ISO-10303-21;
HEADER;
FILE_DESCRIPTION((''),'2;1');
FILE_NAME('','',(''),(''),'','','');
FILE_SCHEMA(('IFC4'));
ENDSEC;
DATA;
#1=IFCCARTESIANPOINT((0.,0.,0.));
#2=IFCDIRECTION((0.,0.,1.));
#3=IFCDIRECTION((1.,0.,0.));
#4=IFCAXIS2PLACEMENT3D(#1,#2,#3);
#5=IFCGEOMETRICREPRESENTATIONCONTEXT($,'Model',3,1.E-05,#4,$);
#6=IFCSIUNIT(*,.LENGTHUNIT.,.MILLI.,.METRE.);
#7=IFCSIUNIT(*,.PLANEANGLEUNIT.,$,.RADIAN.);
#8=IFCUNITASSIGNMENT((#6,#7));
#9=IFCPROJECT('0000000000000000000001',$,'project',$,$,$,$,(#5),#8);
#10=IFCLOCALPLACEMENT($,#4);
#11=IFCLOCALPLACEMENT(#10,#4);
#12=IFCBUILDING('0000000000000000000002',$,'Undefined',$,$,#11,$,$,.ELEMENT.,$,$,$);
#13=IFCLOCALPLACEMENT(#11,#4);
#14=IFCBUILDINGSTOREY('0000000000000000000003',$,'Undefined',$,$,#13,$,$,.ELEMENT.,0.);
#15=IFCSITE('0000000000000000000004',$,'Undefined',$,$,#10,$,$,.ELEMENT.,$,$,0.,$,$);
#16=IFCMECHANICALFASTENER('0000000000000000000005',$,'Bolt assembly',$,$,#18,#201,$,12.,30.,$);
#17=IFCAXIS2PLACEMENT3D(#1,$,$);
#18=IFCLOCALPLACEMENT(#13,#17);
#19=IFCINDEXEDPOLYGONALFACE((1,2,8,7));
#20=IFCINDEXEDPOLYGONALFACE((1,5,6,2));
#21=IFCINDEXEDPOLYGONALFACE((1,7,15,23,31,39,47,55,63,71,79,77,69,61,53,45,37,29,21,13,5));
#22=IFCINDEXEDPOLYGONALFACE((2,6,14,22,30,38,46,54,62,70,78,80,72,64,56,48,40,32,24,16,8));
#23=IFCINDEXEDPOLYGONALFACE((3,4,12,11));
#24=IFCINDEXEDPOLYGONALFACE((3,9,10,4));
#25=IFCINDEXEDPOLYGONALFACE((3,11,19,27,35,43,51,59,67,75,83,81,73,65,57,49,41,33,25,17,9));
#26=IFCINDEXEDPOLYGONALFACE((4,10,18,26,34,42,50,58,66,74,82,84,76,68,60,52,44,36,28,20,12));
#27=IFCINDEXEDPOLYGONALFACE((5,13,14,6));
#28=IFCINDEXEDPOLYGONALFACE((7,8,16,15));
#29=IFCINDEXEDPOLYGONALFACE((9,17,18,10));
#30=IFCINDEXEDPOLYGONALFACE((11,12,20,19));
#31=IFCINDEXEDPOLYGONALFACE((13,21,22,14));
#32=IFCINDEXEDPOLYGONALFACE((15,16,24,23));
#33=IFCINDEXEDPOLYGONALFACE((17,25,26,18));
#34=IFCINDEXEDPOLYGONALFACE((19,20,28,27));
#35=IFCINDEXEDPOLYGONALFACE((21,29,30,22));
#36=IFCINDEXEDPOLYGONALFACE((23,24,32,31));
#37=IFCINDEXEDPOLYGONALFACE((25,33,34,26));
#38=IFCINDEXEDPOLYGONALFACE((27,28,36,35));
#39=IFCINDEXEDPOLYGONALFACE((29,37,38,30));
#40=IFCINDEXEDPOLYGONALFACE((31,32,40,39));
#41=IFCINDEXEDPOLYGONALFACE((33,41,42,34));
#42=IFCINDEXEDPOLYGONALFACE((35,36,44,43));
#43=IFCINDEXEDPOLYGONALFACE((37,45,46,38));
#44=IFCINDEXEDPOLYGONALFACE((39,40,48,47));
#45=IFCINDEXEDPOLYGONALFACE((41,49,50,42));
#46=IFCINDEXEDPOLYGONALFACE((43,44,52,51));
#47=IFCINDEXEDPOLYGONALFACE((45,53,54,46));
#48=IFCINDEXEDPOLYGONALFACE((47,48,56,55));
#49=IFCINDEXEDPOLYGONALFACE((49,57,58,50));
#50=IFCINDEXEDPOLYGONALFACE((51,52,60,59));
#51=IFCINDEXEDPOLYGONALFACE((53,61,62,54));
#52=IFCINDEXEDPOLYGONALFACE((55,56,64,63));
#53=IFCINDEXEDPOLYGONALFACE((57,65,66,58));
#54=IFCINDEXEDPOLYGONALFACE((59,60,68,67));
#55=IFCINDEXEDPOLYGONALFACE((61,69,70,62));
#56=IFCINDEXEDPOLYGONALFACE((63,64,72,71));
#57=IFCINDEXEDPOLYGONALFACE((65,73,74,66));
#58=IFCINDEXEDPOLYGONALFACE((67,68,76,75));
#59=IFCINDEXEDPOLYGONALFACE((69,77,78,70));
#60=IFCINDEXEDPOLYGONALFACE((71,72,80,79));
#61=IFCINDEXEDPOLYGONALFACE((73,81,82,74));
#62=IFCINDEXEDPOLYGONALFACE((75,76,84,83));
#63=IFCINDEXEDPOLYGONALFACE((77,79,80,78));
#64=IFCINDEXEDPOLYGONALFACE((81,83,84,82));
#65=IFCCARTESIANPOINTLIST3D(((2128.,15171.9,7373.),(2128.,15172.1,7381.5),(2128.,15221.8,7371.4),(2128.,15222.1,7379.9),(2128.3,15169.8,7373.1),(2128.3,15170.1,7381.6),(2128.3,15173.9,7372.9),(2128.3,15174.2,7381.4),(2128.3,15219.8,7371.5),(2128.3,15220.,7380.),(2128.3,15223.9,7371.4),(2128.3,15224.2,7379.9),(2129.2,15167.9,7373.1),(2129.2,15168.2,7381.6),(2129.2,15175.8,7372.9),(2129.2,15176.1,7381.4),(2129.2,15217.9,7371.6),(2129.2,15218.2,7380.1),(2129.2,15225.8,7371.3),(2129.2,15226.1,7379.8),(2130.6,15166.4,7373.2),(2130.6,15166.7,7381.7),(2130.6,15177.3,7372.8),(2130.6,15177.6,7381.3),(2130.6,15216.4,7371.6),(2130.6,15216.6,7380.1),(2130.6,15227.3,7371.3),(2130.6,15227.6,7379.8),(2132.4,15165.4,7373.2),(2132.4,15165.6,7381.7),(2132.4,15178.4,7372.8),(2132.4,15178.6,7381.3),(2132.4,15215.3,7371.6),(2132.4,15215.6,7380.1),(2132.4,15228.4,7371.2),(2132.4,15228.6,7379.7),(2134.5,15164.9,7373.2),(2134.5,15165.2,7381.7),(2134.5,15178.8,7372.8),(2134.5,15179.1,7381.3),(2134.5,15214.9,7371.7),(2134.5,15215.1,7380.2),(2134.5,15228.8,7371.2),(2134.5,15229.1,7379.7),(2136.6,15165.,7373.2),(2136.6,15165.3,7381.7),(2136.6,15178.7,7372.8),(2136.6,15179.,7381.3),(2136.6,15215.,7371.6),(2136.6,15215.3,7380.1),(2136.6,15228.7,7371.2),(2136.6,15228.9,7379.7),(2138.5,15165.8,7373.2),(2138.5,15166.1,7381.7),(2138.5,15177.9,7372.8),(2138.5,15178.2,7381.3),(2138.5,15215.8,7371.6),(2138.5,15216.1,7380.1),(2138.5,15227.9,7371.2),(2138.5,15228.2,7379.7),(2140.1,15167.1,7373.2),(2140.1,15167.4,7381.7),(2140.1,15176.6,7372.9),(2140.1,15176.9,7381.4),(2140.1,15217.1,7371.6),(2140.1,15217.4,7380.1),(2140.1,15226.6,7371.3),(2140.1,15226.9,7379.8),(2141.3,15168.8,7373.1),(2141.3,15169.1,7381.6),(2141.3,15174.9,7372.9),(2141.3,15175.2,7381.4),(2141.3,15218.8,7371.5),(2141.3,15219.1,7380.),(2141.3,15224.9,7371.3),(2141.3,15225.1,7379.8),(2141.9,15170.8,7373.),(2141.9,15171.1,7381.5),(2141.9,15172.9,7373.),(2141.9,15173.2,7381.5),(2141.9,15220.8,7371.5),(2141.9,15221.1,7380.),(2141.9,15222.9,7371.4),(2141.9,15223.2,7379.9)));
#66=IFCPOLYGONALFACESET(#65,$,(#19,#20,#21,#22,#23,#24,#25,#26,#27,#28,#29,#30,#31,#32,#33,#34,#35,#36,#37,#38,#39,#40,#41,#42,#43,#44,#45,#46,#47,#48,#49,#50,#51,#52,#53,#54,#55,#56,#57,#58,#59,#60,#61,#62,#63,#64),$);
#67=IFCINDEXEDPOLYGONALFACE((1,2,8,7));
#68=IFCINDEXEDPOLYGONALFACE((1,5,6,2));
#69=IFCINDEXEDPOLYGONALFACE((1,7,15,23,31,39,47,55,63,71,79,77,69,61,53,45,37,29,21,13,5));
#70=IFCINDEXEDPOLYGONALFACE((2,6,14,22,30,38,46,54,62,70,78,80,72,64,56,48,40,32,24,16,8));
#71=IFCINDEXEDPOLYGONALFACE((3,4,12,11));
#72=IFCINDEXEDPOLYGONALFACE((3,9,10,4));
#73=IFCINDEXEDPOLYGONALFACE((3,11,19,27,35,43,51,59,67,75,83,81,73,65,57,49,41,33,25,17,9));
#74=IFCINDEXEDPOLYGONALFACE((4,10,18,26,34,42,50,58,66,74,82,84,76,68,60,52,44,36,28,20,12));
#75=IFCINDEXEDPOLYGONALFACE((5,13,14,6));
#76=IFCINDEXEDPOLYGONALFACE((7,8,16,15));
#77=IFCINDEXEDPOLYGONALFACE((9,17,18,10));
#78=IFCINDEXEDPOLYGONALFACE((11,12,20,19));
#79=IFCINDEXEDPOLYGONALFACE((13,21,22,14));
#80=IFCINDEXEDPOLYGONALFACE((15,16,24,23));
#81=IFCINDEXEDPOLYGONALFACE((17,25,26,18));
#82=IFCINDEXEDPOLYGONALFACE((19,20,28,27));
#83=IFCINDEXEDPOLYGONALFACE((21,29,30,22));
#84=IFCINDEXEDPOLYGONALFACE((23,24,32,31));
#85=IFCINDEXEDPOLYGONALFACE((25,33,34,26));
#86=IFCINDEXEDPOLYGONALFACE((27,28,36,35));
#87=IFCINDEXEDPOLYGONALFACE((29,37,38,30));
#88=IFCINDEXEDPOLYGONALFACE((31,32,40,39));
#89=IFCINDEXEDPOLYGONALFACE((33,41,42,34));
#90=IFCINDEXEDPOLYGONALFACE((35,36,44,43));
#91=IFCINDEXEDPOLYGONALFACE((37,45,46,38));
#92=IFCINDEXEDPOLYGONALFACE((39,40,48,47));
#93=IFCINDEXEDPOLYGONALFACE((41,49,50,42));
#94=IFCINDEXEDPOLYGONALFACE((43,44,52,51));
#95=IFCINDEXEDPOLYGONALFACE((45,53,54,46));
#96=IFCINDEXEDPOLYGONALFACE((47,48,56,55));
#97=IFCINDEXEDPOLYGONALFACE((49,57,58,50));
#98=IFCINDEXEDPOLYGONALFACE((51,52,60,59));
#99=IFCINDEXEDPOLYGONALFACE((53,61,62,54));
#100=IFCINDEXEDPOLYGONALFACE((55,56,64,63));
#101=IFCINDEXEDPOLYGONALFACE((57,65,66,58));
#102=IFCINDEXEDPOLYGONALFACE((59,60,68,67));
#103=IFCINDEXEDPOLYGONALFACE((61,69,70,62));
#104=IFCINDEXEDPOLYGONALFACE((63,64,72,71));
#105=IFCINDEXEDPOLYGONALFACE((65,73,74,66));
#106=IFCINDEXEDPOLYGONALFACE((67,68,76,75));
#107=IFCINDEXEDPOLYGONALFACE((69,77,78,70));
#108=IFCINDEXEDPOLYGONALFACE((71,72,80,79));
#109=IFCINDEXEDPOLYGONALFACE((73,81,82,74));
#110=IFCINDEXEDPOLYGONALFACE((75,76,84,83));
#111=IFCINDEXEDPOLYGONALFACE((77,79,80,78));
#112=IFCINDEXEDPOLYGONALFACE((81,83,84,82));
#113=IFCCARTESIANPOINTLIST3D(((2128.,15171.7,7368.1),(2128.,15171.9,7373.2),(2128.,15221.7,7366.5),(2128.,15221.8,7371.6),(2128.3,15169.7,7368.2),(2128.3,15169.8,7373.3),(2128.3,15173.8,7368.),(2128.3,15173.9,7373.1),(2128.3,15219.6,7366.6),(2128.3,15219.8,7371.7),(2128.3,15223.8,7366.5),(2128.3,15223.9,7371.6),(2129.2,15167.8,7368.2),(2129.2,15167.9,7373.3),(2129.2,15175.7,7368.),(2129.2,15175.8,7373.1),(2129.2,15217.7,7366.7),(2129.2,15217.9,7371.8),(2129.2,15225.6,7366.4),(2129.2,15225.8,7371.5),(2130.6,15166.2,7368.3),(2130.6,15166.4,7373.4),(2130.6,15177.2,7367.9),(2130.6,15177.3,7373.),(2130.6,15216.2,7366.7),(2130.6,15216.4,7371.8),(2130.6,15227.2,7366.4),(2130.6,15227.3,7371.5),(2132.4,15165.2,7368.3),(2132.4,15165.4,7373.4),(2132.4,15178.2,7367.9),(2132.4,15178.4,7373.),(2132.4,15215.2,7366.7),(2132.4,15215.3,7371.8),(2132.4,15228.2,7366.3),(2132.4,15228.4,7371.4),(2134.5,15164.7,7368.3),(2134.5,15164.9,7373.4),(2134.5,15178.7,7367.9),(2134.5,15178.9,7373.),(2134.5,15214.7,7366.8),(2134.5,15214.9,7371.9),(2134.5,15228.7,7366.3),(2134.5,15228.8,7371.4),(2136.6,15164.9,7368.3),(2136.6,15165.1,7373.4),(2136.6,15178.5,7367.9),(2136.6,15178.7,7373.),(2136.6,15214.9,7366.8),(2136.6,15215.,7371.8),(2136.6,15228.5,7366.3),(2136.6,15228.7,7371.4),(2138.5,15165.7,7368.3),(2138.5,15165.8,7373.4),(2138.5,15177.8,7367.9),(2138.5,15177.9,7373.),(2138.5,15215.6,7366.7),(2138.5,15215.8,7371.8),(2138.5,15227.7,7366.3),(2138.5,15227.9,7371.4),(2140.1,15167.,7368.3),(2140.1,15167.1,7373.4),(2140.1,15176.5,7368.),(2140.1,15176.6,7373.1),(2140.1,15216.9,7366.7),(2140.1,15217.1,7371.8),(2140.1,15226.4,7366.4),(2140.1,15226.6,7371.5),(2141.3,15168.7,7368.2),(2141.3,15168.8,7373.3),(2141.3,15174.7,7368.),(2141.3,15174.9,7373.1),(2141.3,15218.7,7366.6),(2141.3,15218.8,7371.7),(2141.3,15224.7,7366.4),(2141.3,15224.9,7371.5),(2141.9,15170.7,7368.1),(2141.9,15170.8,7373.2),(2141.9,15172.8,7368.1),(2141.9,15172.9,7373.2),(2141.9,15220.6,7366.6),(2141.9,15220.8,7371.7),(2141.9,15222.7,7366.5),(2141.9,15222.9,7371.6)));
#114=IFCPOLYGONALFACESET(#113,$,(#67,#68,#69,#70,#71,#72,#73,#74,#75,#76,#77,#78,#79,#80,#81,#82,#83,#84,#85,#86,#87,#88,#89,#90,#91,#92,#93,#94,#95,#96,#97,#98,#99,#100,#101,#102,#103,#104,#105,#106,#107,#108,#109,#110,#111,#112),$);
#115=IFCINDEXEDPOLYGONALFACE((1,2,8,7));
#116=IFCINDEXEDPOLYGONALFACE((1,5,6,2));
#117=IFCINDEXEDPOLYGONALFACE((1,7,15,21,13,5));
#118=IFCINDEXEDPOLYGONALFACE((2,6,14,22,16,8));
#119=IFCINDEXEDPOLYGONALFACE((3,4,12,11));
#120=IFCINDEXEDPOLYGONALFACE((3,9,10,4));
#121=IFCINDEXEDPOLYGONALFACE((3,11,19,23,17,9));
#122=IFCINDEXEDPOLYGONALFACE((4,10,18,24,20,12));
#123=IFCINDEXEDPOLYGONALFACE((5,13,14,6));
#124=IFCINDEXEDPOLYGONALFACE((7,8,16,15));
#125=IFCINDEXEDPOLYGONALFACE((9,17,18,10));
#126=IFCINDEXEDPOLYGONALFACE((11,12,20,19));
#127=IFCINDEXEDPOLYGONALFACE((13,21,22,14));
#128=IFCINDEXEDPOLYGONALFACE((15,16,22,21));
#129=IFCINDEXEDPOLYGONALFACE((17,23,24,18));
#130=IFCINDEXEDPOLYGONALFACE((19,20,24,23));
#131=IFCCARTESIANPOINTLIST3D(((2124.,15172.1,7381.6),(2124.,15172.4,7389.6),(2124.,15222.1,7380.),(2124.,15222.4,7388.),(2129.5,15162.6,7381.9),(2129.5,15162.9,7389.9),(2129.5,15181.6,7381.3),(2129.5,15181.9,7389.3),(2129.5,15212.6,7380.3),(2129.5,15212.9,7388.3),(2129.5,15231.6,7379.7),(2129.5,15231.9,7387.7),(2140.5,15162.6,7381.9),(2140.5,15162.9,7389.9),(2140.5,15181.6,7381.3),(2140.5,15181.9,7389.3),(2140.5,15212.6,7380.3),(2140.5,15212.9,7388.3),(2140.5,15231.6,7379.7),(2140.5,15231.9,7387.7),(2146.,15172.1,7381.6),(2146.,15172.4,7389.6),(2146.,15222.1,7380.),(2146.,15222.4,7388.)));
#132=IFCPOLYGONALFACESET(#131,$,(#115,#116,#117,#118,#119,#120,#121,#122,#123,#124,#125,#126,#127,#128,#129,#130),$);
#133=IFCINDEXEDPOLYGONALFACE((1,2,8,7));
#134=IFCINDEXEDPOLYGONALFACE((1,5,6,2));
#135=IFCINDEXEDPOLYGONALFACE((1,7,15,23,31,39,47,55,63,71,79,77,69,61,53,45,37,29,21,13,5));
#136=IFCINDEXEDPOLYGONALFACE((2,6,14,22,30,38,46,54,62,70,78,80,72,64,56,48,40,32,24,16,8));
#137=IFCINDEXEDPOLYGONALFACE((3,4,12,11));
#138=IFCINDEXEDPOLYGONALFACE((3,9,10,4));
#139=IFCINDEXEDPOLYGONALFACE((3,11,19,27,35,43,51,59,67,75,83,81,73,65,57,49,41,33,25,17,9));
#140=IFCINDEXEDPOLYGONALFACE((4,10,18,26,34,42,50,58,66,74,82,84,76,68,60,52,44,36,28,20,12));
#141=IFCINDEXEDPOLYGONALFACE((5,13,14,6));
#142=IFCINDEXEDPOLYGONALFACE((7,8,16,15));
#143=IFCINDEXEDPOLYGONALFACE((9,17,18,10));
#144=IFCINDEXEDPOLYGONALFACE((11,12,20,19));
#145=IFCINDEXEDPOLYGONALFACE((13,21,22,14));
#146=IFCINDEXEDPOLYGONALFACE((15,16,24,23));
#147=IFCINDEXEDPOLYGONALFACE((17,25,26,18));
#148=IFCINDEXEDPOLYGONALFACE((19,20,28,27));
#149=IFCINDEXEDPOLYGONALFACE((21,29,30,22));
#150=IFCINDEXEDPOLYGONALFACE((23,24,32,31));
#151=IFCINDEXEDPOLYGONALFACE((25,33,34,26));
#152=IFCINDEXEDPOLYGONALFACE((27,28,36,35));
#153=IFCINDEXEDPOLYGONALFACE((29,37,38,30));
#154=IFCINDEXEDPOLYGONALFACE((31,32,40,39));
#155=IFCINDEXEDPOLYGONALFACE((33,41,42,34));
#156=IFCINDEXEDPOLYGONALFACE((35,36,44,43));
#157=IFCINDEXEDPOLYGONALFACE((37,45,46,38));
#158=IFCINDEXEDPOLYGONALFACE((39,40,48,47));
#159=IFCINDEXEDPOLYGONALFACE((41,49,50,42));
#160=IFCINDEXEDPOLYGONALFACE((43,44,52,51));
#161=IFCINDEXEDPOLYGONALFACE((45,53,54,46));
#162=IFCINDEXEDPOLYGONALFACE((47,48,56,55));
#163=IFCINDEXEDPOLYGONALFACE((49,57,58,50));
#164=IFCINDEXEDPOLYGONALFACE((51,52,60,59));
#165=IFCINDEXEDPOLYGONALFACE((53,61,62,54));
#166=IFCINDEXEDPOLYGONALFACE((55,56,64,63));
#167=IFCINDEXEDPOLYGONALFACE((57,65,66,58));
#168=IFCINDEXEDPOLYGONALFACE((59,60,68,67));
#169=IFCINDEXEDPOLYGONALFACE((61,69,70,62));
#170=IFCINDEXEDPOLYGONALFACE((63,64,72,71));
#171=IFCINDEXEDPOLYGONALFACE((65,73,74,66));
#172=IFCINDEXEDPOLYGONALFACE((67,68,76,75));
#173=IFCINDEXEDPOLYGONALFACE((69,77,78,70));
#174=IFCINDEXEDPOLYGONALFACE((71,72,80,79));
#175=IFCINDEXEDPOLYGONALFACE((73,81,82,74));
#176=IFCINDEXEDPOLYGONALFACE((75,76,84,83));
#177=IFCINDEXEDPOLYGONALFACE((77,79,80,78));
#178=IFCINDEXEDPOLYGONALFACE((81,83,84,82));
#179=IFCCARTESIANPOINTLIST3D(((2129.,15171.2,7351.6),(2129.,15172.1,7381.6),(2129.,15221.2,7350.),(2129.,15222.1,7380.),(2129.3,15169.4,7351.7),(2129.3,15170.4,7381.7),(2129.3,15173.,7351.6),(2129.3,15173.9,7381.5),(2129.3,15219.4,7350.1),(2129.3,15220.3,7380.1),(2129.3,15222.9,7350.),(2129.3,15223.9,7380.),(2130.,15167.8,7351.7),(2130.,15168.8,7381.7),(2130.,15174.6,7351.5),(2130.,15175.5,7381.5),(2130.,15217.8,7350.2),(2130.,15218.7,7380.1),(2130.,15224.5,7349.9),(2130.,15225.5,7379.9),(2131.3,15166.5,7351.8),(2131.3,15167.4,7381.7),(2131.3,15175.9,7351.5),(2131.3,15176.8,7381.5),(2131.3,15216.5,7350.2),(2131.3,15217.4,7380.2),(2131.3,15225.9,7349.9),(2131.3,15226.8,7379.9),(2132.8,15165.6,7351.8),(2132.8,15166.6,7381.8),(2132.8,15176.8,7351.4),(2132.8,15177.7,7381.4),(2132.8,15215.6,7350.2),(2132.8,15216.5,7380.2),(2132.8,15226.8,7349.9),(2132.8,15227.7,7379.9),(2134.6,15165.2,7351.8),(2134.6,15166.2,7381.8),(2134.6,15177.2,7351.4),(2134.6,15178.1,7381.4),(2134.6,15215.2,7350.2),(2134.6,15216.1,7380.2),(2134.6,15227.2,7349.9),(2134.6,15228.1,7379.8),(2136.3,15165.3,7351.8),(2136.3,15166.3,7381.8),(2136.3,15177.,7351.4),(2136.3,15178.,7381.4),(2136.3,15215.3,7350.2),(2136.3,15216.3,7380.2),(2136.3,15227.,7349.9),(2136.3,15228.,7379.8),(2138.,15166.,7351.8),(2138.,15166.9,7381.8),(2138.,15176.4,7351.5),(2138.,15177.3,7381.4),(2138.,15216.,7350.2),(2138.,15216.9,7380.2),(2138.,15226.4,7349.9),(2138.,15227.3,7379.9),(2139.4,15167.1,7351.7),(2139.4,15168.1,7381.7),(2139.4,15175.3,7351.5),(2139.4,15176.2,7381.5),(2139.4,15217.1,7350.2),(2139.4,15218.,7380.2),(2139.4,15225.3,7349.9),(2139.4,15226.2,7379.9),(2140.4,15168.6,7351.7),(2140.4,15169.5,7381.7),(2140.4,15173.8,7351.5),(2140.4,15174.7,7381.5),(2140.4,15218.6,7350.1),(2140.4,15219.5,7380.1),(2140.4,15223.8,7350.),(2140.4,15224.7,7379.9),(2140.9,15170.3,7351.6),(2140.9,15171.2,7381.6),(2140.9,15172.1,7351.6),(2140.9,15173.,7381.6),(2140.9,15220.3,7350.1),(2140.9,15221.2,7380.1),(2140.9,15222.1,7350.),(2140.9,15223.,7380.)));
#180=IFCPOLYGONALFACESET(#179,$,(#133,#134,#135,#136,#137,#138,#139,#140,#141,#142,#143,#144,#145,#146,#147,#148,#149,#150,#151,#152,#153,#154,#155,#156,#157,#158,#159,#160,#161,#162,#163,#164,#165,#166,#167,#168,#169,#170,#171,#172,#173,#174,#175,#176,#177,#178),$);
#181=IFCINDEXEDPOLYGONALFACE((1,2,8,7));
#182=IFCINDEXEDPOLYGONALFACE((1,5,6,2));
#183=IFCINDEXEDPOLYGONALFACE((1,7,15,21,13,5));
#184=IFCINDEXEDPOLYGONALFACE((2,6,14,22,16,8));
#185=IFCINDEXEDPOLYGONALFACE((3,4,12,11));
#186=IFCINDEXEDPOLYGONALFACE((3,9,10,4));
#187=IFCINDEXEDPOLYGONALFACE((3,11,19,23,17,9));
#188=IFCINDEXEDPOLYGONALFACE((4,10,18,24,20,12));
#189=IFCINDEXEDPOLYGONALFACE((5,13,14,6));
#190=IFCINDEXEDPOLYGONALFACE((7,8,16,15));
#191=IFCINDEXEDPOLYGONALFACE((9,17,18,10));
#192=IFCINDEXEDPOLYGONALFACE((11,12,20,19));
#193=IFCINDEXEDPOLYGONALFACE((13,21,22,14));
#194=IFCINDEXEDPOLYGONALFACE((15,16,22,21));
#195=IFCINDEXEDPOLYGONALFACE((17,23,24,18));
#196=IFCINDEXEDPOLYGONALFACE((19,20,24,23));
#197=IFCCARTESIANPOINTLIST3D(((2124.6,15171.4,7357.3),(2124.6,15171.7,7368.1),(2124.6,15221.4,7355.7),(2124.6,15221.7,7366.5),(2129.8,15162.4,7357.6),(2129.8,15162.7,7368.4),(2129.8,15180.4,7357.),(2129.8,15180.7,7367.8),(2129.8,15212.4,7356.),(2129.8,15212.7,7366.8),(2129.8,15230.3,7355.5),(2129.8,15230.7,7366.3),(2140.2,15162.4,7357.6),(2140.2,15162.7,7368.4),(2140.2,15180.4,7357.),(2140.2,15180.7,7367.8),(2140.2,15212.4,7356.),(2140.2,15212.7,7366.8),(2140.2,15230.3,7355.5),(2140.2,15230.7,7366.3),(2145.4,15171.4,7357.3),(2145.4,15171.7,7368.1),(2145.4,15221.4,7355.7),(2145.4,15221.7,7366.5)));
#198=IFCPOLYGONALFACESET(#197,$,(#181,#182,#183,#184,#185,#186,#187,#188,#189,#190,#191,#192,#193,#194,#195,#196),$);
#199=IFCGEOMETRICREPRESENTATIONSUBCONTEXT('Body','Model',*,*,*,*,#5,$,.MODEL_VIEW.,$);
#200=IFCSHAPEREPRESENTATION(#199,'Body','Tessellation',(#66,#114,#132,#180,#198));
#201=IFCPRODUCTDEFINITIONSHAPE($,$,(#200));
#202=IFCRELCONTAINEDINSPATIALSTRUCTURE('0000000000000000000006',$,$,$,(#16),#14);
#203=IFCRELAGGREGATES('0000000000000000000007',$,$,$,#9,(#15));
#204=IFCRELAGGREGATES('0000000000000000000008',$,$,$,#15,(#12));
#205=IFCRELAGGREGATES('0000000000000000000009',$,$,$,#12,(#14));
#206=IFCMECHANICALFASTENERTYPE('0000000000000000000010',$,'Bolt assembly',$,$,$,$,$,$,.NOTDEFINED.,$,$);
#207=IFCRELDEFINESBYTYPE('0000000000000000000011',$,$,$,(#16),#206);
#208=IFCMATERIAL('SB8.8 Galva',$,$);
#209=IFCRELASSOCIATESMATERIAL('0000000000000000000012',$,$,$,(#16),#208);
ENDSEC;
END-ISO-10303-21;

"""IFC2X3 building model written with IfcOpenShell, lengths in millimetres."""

from ifc_helpers import new_model, si_unit, frame, origin_with_axes, origin_2d_with_axis, place, context, subcontext, project, spatial, polyline, circle, outline, extrude, source, transform, mapped, material, type_object, element, save


model = new_model("IFC2X3")

# Units and contexts
model_context = context("Model", 3, precision=1e-05, world=origin_with_axes())
body_context = subcontext(model_context, "Body", "Model", "MODEL_VIEW")
ifc_project = project(units=[si_unit("LENGTHUNIT", "METRE", prefix="MILLI"), si_unit("PLANEANGLEUNIT", "RADIAN")], contexts=[model_context])

# Site, building, storey
site_placement = place(None, origin_with_axes())
site = spatial("IfcSite", under=ifc_project, at=site_placement, Name="Undefined", CompositionType="ELEMENT", RefElevation=0.0)
building_placement = place(site_placement, origin_with_axes())
building = spatial("IfcBuilding", under=site, at=building_placement, Name="Undefined", CompositionType="ELEMENT")
storey_placement = place(building_placement, origin_with_axes())
storey = spatial("IfcBuildingStorey", under=building, at=storey_placement, Name="Undefined", CompositionType="ELEMENT", Elevation=0.0)

# Mechanical fastener
mechanical_fastener_type = type_object("IfcMechanicalFastenerType", Name="Bolt assembly")
ifc_material_1 = material(Name="SB8.8 Galva")
shared_shape_1 = source(origin_with_axes(), body_context, "Body", "SweptSolid", [
    extrude(circle(Radius=7.0, at=origin_2d_with_axis()), frame((0.0, -8.4, 0.0), z_axis=(0.0, 1.0, 0.0), x_axis=(1.0, 0.0, 0.0)), (0.0, 0.0, 1.0), 8.5),
    extrude(circle(Radius=7.0, at=origin_2d_with_axis()), frame((0.0, -0.1, 0.0), z_axis=(0.0, 1.0, 0.0), x_axis=(1.0, 0.0, 0.0)), (0.0, 0.0, 1.0), 5.1),
    extrude(outline(polyline([(11.0, 0.0), (5.5, 9.5), (-5.5, 9.5), (-11.0, 0.0), (-5.5, -9.5), (5.5, -9.5), (11.0, 0.0)])), frame((0.0, -16.5, 0.0), z_axis=(0.0, 1.0, 0.0), x_axis=(1.0, 0.0, 0.0)), (0.0, 0.0, 1.0), 8.0),
    extrude(circle(Radius=6.0, at=origin_2d_with_axis()), frame((0.0, -8.5, 0.0), z_axis=(0.0, 1.0, 0.0), x_axis=(1.0, 0.0, 0.0)), (0.0, 0.0, 1.0), 30.0),
    extrude(outline(polyline([(10.4, 0.0), (5.2, 9.0), (-5.2, 9.0), (-10.4, 0.0), (-5.2, -9.0), (5.2, -9.0), (10.4, 0.0)])), frame((0.0, 5.0, 0.0), z_axis=(0.0, 1.0, 0.0), x_axis=(1.0, 0.0, 0.0)), (0.0, 0.0, 1.0), 10.8),
])
for number, where, z_axis, x_axis, name in (
    (1, (2135.0, 15196.9, 7372.3), (0.0, -0.999507, 0.031411), (-1.0, 0.0, 0.0), "Bolt assembly"),
):
    element("IfcMechanicalFastener", number, at=place(storey_placement, frame(where, z_axis=z_axis, x_axis=x_axis)), inside=storey, type_object=mechanical_fastener_type, material=ifc_material_1, Name=name, NominalDiameter=12.0, NominalLength=30.0, context=body_context, shape_type="MappedRepresentation", body=[
        mapped(shared_shape_1, transform((0.0, 0.0, -25.0))),
        mapped(shared_shape_1, transform((0.0, 0.0, 25.0))),
    ])

save(model, "model.ifc")
